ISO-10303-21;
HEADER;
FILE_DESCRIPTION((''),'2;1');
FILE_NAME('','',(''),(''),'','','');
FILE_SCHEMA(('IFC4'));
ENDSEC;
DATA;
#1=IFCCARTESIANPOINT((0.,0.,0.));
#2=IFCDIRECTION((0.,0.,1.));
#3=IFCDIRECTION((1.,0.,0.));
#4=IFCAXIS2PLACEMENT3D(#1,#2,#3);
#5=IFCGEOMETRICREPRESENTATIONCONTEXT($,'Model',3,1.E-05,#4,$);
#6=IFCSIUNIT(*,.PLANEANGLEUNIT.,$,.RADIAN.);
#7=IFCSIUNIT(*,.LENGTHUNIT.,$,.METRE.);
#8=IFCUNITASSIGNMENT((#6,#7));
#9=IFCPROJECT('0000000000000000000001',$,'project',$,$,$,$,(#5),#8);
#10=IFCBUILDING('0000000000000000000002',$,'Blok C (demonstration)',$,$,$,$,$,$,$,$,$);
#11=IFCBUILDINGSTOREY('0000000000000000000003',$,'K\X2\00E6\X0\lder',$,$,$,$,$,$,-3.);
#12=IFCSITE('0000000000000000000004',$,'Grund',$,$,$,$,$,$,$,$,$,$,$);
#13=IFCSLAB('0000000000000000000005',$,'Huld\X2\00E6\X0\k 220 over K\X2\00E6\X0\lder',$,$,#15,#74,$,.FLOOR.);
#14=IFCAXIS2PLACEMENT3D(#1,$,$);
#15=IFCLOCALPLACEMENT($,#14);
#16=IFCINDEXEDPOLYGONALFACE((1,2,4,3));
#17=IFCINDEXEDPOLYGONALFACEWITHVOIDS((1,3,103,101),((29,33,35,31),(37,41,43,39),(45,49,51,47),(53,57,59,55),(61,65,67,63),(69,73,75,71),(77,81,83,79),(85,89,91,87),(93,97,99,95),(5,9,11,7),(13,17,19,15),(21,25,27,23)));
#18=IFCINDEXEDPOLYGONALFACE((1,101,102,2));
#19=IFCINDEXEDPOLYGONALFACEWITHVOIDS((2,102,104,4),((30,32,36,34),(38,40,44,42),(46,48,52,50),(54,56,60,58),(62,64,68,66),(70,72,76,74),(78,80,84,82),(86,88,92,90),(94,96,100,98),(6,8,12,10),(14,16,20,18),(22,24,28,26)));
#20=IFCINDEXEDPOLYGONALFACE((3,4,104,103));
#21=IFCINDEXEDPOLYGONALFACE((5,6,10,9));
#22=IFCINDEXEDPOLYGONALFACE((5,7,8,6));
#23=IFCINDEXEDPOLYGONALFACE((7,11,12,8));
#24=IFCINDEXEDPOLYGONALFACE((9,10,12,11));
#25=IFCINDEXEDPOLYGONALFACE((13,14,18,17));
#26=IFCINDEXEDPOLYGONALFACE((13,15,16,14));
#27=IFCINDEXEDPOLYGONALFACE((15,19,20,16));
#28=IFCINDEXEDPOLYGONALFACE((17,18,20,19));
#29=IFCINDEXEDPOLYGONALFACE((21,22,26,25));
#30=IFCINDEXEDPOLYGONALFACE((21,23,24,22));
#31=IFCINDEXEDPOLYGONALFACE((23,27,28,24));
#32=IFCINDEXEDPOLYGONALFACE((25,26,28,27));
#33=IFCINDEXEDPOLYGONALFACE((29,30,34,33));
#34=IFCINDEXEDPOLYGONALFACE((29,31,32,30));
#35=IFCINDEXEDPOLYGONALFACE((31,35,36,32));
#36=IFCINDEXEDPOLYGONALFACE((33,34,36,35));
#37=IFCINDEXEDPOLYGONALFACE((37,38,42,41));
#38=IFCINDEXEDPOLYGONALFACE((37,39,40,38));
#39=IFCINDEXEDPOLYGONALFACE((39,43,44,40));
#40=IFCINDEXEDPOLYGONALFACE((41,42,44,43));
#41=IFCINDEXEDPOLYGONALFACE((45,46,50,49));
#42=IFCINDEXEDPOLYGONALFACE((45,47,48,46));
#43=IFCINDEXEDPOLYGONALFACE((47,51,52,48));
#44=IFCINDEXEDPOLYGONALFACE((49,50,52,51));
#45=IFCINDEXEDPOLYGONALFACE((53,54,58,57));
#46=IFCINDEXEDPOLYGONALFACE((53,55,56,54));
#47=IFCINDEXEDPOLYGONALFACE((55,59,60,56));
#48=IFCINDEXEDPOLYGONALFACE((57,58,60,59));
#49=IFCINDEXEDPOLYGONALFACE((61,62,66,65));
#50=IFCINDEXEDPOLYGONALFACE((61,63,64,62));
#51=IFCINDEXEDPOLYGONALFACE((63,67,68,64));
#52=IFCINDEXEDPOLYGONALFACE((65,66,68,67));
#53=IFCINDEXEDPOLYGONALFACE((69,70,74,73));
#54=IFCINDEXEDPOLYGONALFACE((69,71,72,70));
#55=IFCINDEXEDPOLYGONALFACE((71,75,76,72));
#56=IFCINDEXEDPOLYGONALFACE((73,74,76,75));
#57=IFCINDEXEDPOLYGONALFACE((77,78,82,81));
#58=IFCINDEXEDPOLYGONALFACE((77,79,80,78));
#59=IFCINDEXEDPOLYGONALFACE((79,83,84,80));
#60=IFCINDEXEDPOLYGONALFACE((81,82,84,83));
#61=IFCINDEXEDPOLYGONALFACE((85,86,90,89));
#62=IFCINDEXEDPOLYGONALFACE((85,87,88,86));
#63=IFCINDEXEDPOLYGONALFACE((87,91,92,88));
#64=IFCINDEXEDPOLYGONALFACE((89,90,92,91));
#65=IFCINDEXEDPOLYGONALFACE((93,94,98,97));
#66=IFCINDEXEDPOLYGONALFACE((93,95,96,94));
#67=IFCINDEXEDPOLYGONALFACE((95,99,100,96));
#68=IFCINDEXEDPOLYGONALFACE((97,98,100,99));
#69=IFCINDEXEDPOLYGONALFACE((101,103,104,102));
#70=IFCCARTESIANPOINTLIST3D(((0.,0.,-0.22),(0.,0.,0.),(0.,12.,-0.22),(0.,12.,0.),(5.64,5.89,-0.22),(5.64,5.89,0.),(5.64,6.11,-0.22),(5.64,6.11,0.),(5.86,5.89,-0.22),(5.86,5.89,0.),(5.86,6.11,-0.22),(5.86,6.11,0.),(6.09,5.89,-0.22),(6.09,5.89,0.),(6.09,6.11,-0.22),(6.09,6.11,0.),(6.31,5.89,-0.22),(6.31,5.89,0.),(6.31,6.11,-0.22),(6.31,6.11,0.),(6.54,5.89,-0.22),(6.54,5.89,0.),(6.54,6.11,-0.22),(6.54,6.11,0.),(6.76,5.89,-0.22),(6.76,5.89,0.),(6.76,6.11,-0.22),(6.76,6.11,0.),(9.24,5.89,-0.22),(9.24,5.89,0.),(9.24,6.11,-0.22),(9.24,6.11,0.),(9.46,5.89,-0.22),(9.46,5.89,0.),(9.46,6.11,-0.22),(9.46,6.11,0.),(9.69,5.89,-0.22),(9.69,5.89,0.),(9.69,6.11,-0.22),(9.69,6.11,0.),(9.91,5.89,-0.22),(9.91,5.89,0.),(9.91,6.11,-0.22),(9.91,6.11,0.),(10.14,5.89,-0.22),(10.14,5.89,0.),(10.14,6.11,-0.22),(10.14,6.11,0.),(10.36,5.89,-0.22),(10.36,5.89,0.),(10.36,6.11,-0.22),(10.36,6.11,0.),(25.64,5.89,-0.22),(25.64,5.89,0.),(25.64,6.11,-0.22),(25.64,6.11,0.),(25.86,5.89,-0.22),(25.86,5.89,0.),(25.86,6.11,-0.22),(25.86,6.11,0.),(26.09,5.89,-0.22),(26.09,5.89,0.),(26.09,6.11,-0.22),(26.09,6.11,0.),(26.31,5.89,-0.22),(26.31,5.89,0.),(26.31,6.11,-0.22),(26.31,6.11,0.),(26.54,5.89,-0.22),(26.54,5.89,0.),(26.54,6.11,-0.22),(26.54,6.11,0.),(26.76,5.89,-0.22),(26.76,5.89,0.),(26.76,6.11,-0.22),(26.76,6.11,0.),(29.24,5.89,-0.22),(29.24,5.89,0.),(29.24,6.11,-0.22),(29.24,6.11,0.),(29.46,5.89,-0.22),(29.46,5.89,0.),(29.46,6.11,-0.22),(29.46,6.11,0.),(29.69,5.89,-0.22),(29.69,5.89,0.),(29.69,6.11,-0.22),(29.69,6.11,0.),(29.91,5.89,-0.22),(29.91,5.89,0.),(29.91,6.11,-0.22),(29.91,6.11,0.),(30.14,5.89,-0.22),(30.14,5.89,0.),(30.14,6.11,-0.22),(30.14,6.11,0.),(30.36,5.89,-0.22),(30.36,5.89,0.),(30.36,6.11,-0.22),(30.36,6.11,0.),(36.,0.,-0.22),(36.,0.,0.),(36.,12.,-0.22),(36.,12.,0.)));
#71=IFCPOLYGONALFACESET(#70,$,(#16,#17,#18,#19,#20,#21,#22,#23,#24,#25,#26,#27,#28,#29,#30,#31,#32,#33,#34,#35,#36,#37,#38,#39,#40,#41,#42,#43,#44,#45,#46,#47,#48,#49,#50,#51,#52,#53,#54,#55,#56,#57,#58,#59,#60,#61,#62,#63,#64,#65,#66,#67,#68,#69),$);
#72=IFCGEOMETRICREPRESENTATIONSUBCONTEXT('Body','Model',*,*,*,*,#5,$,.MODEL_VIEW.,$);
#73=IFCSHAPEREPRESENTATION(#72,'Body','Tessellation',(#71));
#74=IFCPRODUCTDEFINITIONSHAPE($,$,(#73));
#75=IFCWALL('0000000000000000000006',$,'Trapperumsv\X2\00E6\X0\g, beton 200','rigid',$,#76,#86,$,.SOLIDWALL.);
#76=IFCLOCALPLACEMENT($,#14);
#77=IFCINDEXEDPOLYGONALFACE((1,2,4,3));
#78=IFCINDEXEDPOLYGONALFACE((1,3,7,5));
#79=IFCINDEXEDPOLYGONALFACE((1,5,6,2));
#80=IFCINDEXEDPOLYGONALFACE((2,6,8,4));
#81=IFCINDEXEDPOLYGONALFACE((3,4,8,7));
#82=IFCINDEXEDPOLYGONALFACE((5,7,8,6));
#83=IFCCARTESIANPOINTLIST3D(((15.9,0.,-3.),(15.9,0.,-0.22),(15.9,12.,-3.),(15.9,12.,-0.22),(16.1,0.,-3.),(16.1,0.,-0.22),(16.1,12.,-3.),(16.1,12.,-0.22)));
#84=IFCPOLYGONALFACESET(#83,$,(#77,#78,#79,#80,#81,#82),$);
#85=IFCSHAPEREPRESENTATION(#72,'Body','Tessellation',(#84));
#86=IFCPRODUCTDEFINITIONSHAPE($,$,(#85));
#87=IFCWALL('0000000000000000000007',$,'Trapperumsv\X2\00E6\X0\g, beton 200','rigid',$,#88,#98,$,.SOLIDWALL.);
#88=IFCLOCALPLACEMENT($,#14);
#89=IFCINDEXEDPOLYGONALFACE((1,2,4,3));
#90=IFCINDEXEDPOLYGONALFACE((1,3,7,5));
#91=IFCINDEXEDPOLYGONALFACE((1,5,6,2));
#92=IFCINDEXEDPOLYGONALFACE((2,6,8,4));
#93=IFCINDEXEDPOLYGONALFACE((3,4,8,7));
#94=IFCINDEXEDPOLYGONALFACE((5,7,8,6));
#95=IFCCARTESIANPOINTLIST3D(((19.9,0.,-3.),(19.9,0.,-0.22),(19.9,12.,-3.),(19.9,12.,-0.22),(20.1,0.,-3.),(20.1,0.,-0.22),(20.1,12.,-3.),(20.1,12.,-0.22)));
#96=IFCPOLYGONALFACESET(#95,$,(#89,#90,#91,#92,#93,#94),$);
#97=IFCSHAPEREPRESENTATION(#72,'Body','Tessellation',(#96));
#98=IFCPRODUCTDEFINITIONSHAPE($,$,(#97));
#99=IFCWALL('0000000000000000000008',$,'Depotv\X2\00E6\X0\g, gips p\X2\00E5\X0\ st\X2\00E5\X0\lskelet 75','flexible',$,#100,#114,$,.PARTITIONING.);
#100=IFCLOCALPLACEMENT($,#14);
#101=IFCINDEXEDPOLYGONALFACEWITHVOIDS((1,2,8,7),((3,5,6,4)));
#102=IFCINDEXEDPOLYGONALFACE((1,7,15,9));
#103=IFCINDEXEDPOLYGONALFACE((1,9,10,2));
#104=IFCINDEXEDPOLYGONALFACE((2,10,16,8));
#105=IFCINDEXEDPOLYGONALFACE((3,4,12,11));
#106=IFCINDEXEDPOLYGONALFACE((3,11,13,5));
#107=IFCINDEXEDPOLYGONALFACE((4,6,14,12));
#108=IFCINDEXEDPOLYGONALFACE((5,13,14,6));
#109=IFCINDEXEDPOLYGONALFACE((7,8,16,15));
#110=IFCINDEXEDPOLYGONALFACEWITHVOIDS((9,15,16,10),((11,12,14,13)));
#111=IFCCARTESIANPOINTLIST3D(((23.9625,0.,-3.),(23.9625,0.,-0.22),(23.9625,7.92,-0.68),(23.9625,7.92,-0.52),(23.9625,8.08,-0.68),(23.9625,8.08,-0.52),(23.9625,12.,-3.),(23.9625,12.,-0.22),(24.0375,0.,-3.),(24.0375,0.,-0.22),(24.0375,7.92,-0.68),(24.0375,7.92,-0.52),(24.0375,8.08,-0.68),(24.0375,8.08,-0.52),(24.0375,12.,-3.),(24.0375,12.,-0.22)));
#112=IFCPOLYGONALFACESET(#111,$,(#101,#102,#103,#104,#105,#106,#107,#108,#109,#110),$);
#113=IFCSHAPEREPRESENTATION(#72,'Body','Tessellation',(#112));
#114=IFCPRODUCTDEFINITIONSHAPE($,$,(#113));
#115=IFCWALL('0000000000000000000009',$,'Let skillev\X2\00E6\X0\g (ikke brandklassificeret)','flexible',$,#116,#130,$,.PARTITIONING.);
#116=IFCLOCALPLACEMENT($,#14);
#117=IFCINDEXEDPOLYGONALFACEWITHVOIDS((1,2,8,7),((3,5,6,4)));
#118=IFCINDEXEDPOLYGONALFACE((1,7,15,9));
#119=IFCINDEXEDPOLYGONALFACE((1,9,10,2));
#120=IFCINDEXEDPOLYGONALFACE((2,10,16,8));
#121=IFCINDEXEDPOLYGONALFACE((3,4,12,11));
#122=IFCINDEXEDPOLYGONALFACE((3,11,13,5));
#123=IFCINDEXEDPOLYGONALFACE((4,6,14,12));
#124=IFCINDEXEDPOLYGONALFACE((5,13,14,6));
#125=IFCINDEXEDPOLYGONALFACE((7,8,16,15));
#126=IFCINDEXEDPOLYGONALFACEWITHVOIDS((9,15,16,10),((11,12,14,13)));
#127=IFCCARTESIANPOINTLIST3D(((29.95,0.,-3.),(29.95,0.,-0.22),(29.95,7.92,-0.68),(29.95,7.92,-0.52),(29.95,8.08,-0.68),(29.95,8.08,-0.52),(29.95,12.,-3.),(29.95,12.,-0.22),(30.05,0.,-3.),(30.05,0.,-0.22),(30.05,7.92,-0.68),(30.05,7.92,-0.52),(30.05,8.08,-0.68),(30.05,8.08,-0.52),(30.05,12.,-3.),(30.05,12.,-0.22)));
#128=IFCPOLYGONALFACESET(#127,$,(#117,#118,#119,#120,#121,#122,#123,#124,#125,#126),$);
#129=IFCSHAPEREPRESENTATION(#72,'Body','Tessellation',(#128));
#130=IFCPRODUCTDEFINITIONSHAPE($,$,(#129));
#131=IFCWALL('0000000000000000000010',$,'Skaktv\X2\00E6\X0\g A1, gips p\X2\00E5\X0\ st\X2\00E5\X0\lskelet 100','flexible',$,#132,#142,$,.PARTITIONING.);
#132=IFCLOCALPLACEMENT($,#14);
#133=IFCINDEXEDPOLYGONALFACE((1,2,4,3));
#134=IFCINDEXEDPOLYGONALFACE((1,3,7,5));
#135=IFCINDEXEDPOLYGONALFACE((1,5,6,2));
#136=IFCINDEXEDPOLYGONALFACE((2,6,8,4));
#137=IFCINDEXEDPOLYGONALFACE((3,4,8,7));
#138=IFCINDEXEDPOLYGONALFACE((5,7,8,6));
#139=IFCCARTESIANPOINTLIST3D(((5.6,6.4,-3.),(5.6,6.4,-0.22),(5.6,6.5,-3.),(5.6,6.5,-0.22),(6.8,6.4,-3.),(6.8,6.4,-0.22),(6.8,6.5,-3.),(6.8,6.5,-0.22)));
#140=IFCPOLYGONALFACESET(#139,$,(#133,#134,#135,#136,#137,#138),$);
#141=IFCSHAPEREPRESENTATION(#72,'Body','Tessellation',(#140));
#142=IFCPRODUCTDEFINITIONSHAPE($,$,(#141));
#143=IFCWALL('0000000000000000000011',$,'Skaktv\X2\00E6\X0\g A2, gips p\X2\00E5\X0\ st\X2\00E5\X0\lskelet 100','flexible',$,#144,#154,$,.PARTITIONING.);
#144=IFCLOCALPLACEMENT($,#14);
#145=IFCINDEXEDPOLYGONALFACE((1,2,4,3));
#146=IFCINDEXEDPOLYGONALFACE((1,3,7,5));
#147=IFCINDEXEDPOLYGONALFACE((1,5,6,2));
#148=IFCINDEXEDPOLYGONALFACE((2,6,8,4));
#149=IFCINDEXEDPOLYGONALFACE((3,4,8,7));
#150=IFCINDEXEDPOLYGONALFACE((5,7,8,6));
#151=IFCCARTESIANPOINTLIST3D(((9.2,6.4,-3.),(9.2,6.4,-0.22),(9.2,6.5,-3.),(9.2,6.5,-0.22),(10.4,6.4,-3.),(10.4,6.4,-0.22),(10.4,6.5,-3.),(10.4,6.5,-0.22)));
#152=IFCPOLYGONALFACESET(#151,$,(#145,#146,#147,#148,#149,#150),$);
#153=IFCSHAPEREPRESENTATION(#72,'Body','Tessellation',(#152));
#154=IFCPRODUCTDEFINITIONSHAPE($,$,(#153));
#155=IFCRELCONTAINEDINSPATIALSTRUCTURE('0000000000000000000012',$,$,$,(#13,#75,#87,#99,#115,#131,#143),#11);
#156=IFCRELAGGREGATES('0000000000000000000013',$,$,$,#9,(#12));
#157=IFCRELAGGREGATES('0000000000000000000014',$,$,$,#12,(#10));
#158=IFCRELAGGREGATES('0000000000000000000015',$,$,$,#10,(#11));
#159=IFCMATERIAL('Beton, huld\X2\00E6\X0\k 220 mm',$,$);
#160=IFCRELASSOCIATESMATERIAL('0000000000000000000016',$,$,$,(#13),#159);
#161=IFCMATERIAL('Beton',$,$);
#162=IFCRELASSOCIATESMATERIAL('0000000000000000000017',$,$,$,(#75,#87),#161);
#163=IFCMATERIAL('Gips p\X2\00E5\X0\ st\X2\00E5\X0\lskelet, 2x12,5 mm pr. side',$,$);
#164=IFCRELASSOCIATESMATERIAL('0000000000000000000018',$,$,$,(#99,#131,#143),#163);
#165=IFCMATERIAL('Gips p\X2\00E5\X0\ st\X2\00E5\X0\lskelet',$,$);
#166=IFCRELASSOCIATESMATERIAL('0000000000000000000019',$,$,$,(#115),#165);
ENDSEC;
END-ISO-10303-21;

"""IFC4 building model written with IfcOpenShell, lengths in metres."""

from ifc_helpers import new_model, si_unit, frame, origin_with_axes, place, context, subcontext, project, spatial, polyline, outline, extrude, material, element, save


model = new_model("IFC4")

# Units and contexts
model_context = context("Model", 3, precision=1e-05, world=origin_with_axes())
body_context = subcontext(model_context, "Body", "Model", "MODEL_VIEW")
ifc_project = project(units=[si_unit("PLANEANGLEUNIT", "RADIAN"), si_unit("LENGTHUNIT", "METRE")], contexts=[model_context])

# Site, building, storey
site = spatial("IfcSite", under=ifc_project, Name="Grund")
building = spatial("IfcBuilding", under=site, Name="Blok C (demonstration)")
storey = spatial("IfcBuildingStorey", under=building, Name="Kælder", Elevation=-3.0)

# Slab, openings
ifc_material_1 = material(Name="Beton, huldæk 220 mm")
slab_placement = place(None, origin_with_axes())
slab = element("IfcSlab", 1, at=slab_placement, inside=storey, material=ifc_material_1, Name="Huldæk 220 over Kælder", PredefinedType="FLOOR", context=body_context, shape_type="SweptSolid", body=[
    extrude(outline(polyline([(0.0, 0.0), (36.0, 0.0), (36.0, 12.0), (0.0, 12.0), (0.0, 0.0)])), frame((0.0, 0.0, -0.22)), (0.0, 0.0, 1.0), 0.22),
])
opening_1_placement = place(slab_placement, origin_with_axes())
element("IfcOpeningElement", 2, at=opening_1_placement, cuts=slab, PredefinedType="OPENING", context=body_context, shape_type="SweptSolid", body=[
    extrude(outline(polyline([(5.64, 5.89), (5.86, 5.89), (5.86, 6.11), (5.64, 6.11), (5.64, 5.89)])), frame((0.0, 0.0, -0.23)), (0.0, 0.0, 1.0), 0.24),
])
opening_2_placement = place(slab_placement, origin_with_axes())
element("IfcOpeningElement", 3, at=opening_2_placement, cuts=slab, PredefinedType="OPENING", context=body_context, shape_type="SweptSolid", body=[
    extrude(outline(polyline([(6.09, 5.89), (6.31, 5.89), (6.31, 6.11), (6.09, 6.11), (6.09, 5.89)])), frame((0.0, 0.0, -0.23)), (0.0, 0.0, 1.0), 0.24),
])
opening_3_placement = place(slab_placement, origin_with_axes())
element("IfcOpeningElement", 4, at=opening_3_placement, cuts=slab, PredefinedType="OPENING", context=body_context, shape_type="SweptSolid", body=[
    extrude(outline(polyline([(6.54, 5.89), (6.76, 5.89), (6.76, 6.11), (6.54, 6.11), (6.54, 5.89)])), frame((0.0, 0.0, -0.23)), (0.0, 0.0, 1.0), 0.24),
])
opening_4_placement = place(slab_placement, origin_with_axes())
element("IfcOpeningElement", 5, at=opening_4_placement, cuts=slab, PredefinedType="OPENING", context=body_context, shape_type="SweptSolid", body=[
    extrude(outline(polyline([(9.24, 5.89), (9.46, 5.89), (9.46, 6.11), (9.24, 6.11), (9.24, 5.89)])), frame((0.0, 0.0, -0.23)), (0.0, 0.0, 1.0), 0.24),
])
opening_5_placement = place(slab_placement, origin_with_axes())
element("IfcOpeningElement", 6, at=opening_5_placement, cuts=slab, PredefinedType="OPENING", context=body_context, shape_type="SweptSolid", body=[
    extrude(outline(polyline([(9.69, 5.89), (9.91, 5.89), (9.91, 6.11), (9.69, 6.11), (9.69, 5.89)])), frame((0.0, 0.0, -0.23)), (0.0, 0.0, 1.0), 0.24),
])
opening_6_placement = place(slab_placement, origin_with_axes())
element("IfcOpeningElement", 7, at=opening_6_placement, cuts=slab, PredefinedType="OPENING", context=body_context, shape_type="SweptSolid", body=[
    extrude(outline(polyline([(10.14, 5.89), (10.36, 5.89), (10.36, 6.11), (10.14, 6.11), (10.14, 5.89)])), frame((0.0, 0.0, -0.23)), (0.0, 0.0, 1.0), 0.24),
])
opening_7_placement = place(slab_placement, origin_with_axes())
element("IfcOpeningElement", 8, at=opening_7_placement, cuts=slab, PredefinedType="OPENING", context=body_context, shape_type="SweptSolid", body=[
    extrude(outline(polyline([(25.64, 5.89), (25.86, 5.89), (25.86, 6.11), (25.64, 6.11), (25.64, 5.89)])), frame((0.0, 0.0, -0.23)), (0.0, 0.0, 1.0), 0.24),
])
opening_8_placement = place(slab_placement, origin_with_axes())
element("IfcOpeningElement", 9, at=opening_8_placement, cuts=slab, PredefinedType="OPENING", context=body_context, shape_type="SweptSolid", body=[
    extrude(outline(polyline([(26.09, 5.89), (26.31, 5.89), (26.31, 6.11), (26.09, 6.11), (26.09, 5.89)])), frame((0.0, 0.0, -0.23)), (0.0, 0.0, 1.0), 0.24),
])
opening_9_placement = place(slab_placement, origin_with_axes())
element("IfcOpeningElement", 10, at=opening_9_placement, cuts=slab, PredefinedType="OPENING", context=body_context, shape_type="SweptSolid", body=[
    extrude(outline(polyline([(26.54, 5.89), (26.76, 5.89), (26.76, 6.11), (26.54, 6.11), (26.54, 5.89)])), frame((0.0, 0.0, -0.23)), (0.0, 0.0, 1.0), 0.24),
])
opening_10_placement = place(slab_placement, origin_with_axes())
element("IfcOpeningElement", 11, at=opening_10_placement, cuts=slab, PredefinedType="OPENING", context=body_context, shape_type="SweptSolid", body=[
    extrude(outline(polyline([(29.24, 5.89), (29.46, 5.89), (29.46, 6.11), (29.24, 6.11), (29.24, 5.89)])), frame((0.0, 0.0, -0.23)), (0.0, 0.0, 1.0), 0.24),
])
opening_11_placement = place(slab_placement, origin_with_axes())
element("IfcOpeningElement", 12, at=opening_11_placement, cuts=slab, PredefinedType="OPENING", context=body_context, shape_type="SweptSolid", body=[
    extrude(outline(polyline([(29.69, 5.89), (29.91, 5.89), (29.91, 6.11), (29.69, 6.11), (29.69, 5.89)])), frame((0.0, 0.0, -0.23)), (0.0, 0.0, 1.0), 0.24),
])
opening_12_placement = place(slab_placement, origin_with_axes())
element("IfcOpeningElement", 13, at=opening_12_placement, cuts=slab, PredefinedType="OPENING", context=body_context, shape_type="SweptSolid", body=[
    extrude(outline(polyline([(30.14, 5.89), (30.36, 5.89), (30.36, 6.11), (30.14, 6.11), (30.14, 5.89)])), frame((0.0, 0.0, -0.23)), (0.0, 0.0, 1.0), 0.24),
])

# Walls
ifc_material_2 = material(Name="Beton")
wall_1_placement = place(None, origin_with_axes())
element("IfcWall", 14, at=wall_1_placement, inside=storey, material=ifc_material_2, Name="Trapperumsvæg, beton 200", Description="rigid", PredefinedType="SOLIDWALL", context=body_context, shape_type="SweptSolid", body=[
    extrude(outline(polyline([(15.9, 0.0), (16.1, 0.0), (16.1, 12.0), (15.9, 12.0), (15.9, 0.0)])), frame((0.0, 0.0, -3.0)), (0.0, 0.0, 1.0), 2.78),
])
wall_2_placement = place(None, origin_with_axes())
element("IfcWall", 15, at=wall_2_placement, inside=storey, material=ifc_material_2, Name="Trapperumsvæg, beton 200", Description="rigid", PredefinedType="SOLIDWALL", context=body_context, shape_type="SweptSolid", body=[
    extrude(outline(polyline([(19.9, 0.0), (20.1, 0.0), (20.1, 12.0), (19.9, 12.0), (19.9, 0.0)])), frame((0.0, 0.0, -3.0)), (0.0, 0.0, 1.0), 2.78),
])

# Walls, openings
ifc_material_3 = material(Name="Gips på stålskelet, 2x12,5 mm pr. side")
wall_3_placement = place(None, origin_with_axes())
wall_3 = element("IfcWall", 16, at=wall_3_placement, inside=storey, material=ifc_material_3, Name="Depotvæg, gips på stålskelet 75", Description="flexible", PredefinedType="PARTITIONING", context=body_context, shape_type="SweptSolid", body=[
    extrude(outline(polyline([(23.9625, 0.0), (24.0375, 0.0), (24.0375, 12.0), (23.9625, 12.0), (23.9625, 0.0)])), frame((0.0, 0.0, -3.0)), (0.0, 0.0, 1.0), 2.78),
])
opening_13_placement = place(wall_3_placement, origin_with_axes())
element("IfcOpeningElement", 17, at=opening_13_placement, cuts=wall_3, PredefinedType="OPENING", context=body_context, shape_type="SweptSolid", body=[
    extrude(outline(polyline([(23.88, 7.92), (24.12, 7.92), (24.12, 8.08), (23.88, 8.08), (23.88, 7.92)])), frame((0.0, 0.0, -0.68)), (0.0, 0.0, 1.0), 0.16),
])
ifc_material_4 = material(Name="Gips på stålskelet")
wall_4_placement = place(None, origin_with_axes())
wall_4 = element("IfcWall", 18, at=wall_4_placement, inside=storey, material=ifc_material_4, Name="Let skillevæg (ikke brandklassificeret)", Description="flexible", PredefinedType="PARTITIONING", context=body_context, shape_type="SweptSolid", body=[
    extrude(outline(polyline([(29.95, 0.0), (30.05, 0.0), (30.05, 12.0), (29.95, 12.0), (29.95, 0.0)])), frame((0.0, 0.0, -3.0)), (0.0, 0.0, 1.0), 2.78),
])
opening_14_placement = place(wall_4_placement, origin_with_axes())
element("IfcOpeningElement", 19, at=opening_14_placement, cuts=wall_4, PredefinedType="OPENING", context=body_context, shape_type="SweptSolid", body=[
    extrude(outline(polyline([(29.88, 7.92), (30.12, 7.92), (30.12, 8.08), (29.88, 8.08), (29.88, 7.92)])), frame((0.0, 0.0, -0.68)), (0.0, 0.0, 1.0), 0.16),
])

# Walls
wall_5_placement = place(None, origin_with_axes())
element("IfcWall", 20, at=wall_5_placement, inside=storey, material=ifc_material_3, Name="Skaktvæg A1, gips på stålskelet 100", Description="flexible", PredefinedType="PARTITIONING", context=body_context, shape_type="SweptSolid", body=[
    extrude(outline(polyline([(5.6, 6.4), (6.8, 6.4), (6.8, 6.5), (5.6, 6.5), (5.6, 6.4)])), frame((0.0, 0.0, -3.0)), (0.0, 0.0, 1.0), 2.78),
])
wall_6_placement = place(None, origin_with_axes())
element("IfcWall", 21, at=wall_6_placement, inside=storey, material=ifc_material_3, Name="Skaktvæg A2, gips på stålskelet 100", Description="flexible", PredefinedType="PARTITIONING", context=body_context, shape_type="SweptSolid", body=[
    extrude(outline(polyline([(9.2, 6.4), (10.4, 6.4), (10.4, 6.5), (9.2, 6.5), (9.2, 6.4)])), frame((0.0, 0.0, -3.0)), (0.0, 0.0, 1.0), 2.78),
])

save(model, "model.ifc")
